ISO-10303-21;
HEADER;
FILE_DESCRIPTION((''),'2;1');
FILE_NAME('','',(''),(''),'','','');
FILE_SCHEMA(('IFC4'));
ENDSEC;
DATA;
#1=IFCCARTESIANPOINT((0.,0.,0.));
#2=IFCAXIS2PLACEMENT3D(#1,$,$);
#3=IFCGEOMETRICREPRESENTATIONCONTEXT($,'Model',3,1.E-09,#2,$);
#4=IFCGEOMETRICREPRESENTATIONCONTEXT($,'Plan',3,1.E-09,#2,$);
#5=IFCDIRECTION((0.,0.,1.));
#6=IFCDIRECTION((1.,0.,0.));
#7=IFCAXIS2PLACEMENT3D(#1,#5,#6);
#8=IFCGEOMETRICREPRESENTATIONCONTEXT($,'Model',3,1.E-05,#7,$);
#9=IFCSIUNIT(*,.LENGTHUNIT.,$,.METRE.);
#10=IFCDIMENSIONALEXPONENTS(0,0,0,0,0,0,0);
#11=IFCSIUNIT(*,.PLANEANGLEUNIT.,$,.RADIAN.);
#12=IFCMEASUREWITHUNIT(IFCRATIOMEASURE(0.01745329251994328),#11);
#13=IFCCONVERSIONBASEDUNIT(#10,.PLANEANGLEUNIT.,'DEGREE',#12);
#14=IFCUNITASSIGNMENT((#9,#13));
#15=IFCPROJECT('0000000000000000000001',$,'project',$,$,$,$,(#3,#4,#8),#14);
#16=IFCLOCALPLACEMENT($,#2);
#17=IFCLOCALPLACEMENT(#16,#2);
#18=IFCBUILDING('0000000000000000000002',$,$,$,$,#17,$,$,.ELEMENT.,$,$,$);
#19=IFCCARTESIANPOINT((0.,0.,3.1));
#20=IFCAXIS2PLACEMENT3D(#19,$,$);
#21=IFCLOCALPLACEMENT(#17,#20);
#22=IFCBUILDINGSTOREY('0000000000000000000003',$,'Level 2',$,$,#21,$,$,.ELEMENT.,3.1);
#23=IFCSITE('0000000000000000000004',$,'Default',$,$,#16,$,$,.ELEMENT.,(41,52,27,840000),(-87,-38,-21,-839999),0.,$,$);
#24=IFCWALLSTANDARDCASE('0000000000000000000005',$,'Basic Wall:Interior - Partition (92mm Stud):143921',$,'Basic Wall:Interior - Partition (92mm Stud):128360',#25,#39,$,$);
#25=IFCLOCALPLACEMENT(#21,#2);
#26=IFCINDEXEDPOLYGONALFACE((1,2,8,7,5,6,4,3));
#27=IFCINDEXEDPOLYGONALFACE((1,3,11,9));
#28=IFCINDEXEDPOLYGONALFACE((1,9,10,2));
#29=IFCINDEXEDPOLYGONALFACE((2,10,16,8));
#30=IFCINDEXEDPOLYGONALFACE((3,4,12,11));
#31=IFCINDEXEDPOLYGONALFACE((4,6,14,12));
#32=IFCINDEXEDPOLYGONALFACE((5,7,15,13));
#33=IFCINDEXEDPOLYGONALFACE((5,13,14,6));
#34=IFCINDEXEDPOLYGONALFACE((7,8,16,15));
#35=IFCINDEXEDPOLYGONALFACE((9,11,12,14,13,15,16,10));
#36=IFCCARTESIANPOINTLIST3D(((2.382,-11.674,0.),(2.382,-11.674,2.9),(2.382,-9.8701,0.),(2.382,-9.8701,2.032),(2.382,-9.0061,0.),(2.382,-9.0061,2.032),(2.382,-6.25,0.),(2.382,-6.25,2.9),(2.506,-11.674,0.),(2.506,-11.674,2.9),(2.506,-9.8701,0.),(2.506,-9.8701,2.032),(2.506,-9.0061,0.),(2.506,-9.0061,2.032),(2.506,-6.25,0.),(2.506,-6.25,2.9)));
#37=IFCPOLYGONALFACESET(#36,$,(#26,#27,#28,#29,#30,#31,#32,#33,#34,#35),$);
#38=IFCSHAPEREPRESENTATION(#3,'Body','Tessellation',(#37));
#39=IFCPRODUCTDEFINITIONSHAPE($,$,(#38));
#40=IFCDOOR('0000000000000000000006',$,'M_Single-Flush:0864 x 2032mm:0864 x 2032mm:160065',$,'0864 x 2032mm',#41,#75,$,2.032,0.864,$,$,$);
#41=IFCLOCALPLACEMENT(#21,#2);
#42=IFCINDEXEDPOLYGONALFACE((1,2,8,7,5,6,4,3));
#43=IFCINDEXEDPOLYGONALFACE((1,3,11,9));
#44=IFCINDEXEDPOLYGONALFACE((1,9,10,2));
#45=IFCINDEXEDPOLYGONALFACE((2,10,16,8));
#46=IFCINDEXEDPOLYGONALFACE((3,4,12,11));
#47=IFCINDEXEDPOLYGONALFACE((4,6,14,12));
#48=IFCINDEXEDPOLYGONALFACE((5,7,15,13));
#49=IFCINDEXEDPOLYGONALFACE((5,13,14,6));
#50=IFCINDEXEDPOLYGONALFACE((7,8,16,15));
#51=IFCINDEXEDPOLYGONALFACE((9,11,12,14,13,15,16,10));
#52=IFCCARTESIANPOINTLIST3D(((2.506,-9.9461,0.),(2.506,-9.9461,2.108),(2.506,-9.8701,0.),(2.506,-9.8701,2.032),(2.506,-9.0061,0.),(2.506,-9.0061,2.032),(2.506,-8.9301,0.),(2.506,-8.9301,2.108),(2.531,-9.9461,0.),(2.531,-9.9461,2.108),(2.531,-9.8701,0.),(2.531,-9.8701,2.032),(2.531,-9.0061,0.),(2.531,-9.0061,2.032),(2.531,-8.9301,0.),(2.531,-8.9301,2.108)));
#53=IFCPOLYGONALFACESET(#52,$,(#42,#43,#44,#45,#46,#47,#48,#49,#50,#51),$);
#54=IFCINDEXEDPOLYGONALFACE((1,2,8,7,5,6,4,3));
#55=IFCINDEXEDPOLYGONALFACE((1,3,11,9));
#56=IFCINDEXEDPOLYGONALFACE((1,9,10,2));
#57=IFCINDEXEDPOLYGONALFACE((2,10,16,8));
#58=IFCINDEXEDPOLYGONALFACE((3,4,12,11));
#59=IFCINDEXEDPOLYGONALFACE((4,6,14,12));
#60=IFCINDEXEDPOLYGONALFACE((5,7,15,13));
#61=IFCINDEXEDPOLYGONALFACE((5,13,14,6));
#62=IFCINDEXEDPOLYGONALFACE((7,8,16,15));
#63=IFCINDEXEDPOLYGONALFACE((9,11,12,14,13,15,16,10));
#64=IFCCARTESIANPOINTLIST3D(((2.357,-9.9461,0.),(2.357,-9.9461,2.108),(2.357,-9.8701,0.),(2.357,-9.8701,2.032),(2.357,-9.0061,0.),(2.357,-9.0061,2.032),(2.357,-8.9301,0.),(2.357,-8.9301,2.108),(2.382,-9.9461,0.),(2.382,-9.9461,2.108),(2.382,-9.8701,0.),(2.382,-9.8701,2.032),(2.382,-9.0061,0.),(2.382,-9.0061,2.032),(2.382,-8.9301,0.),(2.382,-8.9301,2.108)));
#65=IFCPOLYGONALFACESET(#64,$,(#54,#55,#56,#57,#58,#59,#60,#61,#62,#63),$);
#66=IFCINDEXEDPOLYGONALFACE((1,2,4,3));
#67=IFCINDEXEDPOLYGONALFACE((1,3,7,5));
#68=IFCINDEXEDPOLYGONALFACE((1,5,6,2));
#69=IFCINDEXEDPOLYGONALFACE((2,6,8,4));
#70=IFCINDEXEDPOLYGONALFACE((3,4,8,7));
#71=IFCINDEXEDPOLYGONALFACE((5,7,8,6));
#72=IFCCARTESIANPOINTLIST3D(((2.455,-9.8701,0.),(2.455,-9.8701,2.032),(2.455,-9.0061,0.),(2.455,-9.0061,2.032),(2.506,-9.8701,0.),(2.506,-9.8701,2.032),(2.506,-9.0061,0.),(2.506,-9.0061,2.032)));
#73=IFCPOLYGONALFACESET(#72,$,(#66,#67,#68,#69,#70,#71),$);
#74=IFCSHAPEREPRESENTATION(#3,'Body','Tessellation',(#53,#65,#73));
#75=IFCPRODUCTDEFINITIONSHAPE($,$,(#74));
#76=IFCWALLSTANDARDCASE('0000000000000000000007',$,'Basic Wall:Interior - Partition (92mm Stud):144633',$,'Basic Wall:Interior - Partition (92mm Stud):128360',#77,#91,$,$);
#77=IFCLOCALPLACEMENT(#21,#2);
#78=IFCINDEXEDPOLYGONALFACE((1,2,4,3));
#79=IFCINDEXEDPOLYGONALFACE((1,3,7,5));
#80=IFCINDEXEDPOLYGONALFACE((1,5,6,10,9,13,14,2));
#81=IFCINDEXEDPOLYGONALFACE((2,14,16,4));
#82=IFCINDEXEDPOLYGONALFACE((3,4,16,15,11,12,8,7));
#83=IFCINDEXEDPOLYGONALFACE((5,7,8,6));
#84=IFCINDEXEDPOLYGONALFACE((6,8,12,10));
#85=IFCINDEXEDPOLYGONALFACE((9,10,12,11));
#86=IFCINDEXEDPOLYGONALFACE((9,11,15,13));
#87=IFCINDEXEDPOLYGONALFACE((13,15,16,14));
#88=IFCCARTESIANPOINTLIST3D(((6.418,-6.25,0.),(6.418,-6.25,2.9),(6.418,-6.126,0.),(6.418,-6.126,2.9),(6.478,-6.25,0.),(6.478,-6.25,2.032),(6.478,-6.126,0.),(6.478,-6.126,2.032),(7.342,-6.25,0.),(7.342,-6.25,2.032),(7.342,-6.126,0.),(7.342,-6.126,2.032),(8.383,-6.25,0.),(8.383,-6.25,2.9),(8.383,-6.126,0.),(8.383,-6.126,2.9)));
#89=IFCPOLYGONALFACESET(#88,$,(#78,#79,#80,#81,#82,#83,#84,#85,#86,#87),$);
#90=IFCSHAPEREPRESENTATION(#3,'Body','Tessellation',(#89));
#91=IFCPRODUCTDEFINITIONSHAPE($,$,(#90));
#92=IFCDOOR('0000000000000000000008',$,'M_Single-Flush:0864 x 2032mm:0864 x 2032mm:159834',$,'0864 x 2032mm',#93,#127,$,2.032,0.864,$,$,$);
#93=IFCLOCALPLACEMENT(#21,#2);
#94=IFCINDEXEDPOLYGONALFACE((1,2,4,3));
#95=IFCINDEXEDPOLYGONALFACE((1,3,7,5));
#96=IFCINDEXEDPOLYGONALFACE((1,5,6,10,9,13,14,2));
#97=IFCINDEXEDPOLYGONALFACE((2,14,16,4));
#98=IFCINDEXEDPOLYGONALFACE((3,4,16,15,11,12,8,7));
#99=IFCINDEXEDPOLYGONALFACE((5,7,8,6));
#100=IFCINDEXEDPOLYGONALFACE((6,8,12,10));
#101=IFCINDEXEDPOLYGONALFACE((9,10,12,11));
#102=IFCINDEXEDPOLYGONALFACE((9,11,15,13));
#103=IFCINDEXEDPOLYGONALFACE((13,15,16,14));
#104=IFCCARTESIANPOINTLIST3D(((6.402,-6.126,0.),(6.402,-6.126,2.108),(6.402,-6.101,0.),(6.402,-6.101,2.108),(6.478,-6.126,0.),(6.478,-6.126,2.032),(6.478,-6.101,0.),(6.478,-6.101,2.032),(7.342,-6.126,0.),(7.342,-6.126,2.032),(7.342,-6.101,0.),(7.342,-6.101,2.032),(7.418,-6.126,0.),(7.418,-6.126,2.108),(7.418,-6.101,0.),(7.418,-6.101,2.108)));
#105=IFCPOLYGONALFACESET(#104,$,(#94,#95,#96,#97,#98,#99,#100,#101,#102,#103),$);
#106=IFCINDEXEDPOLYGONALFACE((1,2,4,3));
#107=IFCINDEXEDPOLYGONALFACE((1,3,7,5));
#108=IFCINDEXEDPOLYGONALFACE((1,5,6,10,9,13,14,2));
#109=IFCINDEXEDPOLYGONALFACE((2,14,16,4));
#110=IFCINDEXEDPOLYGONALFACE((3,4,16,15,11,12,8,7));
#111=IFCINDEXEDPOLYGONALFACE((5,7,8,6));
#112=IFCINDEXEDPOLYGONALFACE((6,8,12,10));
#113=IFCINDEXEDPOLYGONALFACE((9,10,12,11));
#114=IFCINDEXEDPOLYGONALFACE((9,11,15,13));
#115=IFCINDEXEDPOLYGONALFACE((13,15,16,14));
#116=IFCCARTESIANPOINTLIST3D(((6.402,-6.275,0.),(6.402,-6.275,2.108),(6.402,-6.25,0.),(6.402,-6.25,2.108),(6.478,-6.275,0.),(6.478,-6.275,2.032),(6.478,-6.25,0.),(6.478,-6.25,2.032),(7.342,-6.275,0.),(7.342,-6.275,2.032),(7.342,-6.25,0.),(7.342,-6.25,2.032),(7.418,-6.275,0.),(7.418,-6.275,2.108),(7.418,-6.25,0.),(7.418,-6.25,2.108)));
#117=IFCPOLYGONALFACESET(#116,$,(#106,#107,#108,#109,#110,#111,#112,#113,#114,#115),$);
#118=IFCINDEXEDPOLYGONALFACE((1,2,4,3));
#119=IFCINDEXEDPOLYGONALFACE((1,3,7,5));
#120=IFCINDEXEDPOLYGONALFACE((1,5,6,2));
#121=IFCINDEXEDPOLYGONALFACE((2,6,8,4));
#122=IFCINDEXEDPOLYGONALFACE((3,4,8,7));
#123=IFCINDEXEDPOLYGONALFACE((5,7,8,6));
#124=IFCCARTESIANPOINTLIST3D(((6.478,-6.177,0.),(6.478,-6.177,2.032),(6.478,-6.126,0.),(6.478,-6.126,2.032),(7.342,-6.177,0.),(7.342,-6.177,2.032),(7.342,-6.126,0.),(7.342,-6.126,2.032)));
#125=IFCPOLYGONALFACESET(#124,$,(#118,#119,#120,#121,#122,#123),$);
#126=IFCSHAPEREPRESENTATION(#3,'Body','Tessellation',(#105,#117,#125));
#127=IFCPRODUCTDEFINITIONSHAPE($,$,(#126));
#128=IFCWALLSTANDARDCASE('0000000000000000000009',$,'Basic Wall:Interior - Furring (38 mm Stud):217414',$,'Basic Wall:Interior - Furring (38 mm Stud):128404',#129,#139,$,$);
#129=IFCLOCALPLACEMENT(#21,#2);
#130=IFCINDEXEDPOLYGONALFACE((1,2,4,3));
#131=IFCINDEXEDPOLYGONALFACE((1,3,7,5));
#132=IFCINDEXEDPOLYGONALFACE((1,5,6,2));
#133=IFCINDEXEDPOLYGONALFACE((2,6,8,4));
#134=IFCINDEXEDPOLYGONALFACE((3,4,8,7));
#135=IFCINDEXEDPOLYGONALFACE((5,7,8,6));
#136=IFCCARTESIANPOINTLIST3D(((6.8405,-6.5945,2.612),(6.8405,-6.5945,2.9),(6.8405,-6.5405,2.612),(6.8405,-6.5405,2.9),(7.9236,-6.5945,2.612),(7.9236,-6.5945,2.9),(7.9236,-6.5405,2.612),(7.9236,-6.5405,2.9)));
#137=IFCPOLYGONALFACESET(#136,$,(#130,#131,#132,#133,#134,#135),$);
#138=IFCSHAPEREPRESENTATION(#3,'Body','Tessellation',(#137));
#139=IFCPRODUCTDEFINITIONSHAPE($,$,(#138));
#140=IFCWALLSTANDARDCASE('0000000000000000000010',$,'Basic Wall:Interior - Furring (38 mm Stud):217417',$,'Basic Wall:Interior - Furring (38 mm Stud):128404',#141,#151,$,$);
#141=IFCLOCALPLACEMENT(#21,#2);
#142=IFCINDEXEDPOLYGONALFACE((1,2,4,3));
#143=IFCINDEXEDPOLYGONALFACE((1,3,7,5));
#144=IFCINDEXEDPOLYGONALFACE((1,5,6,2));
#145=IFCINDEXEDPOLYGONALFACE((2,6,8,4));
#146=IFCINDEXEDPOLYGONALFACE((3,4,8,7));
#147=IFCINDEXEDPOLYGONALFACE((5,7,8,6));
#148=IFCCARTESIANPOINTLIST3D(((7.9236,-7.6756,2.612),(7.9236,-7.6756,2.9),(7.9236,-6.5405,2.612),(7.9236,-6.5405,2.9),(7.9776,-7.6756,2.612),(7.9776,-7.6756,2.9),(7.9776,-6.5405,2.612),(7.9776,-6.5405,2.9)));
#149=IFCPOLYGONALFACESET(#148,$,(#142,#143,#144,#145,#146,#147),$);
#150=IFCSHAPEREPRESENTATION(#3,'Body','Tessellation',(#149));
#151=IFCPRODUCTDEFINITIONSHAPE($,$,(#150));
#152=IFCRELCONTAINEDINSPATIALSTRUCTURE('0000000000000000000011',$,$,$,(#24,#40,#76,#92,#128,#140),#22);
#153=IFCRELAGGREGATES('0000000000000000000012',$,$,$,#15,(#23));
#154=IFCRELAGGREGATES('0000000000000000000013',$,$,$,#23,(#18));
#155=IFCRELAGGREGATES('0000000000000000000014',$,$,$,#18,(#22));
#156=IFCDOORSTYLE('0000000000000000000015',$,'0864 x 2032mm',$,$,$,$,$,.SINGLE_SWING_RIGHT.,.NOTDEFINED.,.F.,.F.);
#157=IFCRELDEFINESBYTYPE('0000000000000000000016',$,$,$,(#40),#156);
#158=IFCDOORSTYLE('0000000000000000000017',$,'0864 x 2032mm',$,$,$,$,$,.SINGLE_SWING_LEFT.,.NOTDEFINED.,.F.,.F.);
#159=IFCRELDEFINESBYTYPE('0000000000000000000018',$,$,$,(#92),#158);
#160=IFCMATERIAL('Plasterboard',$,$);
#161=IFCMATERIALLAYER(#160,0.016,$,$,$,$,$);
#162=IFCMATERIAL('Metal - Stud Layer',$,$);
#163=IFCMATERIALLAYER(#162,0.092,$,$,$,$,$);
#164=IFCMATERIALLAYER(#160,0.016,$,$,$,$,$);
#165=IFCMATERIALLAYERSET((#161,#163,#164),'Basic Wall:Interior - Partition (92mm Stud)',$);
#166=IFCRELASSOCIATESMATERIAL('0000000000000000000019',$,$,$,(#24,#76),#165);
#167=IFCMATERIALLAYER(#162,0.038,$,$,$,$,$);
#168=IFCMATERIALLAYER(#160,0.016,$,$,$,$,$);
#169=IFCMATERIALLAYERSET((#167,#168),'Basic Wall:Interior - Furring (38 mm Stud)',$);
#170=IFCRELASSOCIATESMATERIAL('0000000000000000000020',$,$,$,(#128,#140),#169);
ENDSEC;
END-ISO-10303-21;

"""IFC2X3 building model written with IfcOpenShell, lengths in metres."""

from ifc_helpers import new_model, entity, si_unit, converted_unit, frame, frame_2d, origin, origin_with_axes, origin_2d_with_axis, place, context, project, spatial, polyline, rectangle, outline, extrude, source, transform, mapped, material, layer, layer_set, layer_usage, type_object, type_shapes, element, fill, save


model = new_model("IFC2X3")

# Units and contexts
model_context_1 = context("Model", 3, precision=1e-09, world=origin())
plan_context = context("Plan", 3, precision=1e-09, world=origin())
model_context_2 = context("Model", 3, precision=1e-05, world=origin_with_axes())
ifc_project = project(units=[si_unit("LENGTHUNIT", "METRE"), converted_unit("PLANEANGLEUNIT", "DEGREE", entity("IfcRatioMeasure", 0.01745329251994328), si_unit("PLANEANGLEUNIT", "RADIAN"), dimensions=[0, 0, 0, 0, 0, 0, 0])], contexts=[model_context_1, plan_context, model_context_2])

# Site, building, storey
site_placement = place(None, origin())
site = spatial("IfcSite", under=ifc_project, at=site_placement, Name="Default", CompositionType="ELEMENT", RefLatitude=(41, 52, 27, 840000), RefLongitude=(-87, -38, -21, -839999), RefElevation=0.0)
building_placement = place(site_placement, origin())
building = spatial("IfcBuilding", under=site, at=building_placement, CompositionType="ELEMENT")
storey_placement = place(building_placement, frame((0.0, 0.0, 3.1)))
storey = spatial("IfcBuildingStorey", under=building, at=storey_placement, Name="Level 2", CompositionType="ELEMENT", Elevation=3.1)

# Shared definitions
ifc_material_1 = material(Name="Metal - Stud Layer")
ifc_material_2 = material(Name="Plasterboard")

# Walls, openings, doors
ifc_layer_1 = layer(ifc_material_2, 0.016)
ifc_layer_2 = layer(ifc_material_1, 0.092)
ifc_layer_3 = layer(ifc_material_2, 0.016)
ifc_layer_set_1 = layer_set([ifc_layer_1, ifc_layer_2, ifc_layer_3], Name="Basic Wall:Interior - Partition (92mm Stud)")
ifc_layer_usage_1 = layer_usage(ifc_layer_set_1, "AXIS2", "NEGATIVE", 0.062)
wall_1_placement = place(storey_placement, frame((2.444, -6.25, 0.0), z_axis=(0.0, 0.0, 1.0), x_axis=(0.0, -1.0, 0.0)))
wall_1 = element("IfcWallStandardCase", 1, at=wall_1_placement, inside=storey, material=ifc_layer_usage_1, Name="Basic Wall:Interior - Partition (92mm Stud):143921", ObjectType="Basic Wall:Interior - Partition (92mm Stud):128360", context=model_context_1, shape_type="SweptSolid", body=[
    extrude(rectangle(XDim=5.424, YDim=0.124, at=frame_2d((2.712, 0.0), x_axis=(-1.0, 0.0))), origin(), (0.0, 0.0, 1.0), 2.9),
])
opening_1_placement = place(wall_1_placement, frame((2.7561, -0.062, 0.0)))
opening_1 = element("IfcOpeningElement", 2, at=opening_1_placement, cuts=wall_1, ObjectType="Opening", context=model_context_1, shape_type="SweptSolid", body=[
    extrude(rectangle(XDim=0.864, YDim=2.032, at=frame_2d((1.016, 0.432), x_axis=(0.0, 1.0))), frame((0.0, 0.0, 0.0), z_axis=(0.0, 1.0, 0.0), x_axis=(0.0, 0.0, 1.0)), (0.0, 0.0, 1.0), 0.124),
])
door_style_1 = type_object("IfcDoorStyle", Name="0864 x 2032mm", ConstructionType="NOTDEFINED", OperationType="SINGLE_SWING_RIGHT", ParameterTakesPrecedence=False, Sizeable=False)
shared_shape_1 = source(origin(), model_context_1, "Body", "SweptSolid", [
    extrude(outline(polyline([(-0.508, -1.073), (0.508, -1.073), (0.508, 1.035), (0.432, 1.035), (0.432, -0.997), (-0.432, -0.997), (-0.432, 1.035), (-0.508, 1.035), (-0.508, -1.073)])), frame((0.432, 0.124, 1.035), z_axis=(0.0, 1.0, 0.0), x_axis=(1.0, 0.0, 0.0)), (0.0, 0.0, 1.0), 0.025),
    extrude(outline(polyline([(-1.073, -0.508), (1.035, -0.508), (1.035, -0.432), (-0.997, -0.432), (-0.997, 0.432), (1.035, 0.432), (1.035, 0.508), (-1.073, 0.508), (-1.073, -0.508)])), frame((0.432, -0.025, 1.035), z_axis=(0.0, 1.0, 0.0), x_axis=(0.0, 0.0, -1.0)), (0.0, 0.0, 1.0), 0.025),
    extrude(rectangle(XDim=0.051, YDim=0.864, at=origin_2d_with_axis()), frame((0.432, 0.0985, 0.0), z_axis=(0.0, 0.0, 1.0), x_axis=(0.0, 1.0, 0.0)), (0.0, 0.0, 1.0), 2.032),
])
type_shapes(door_style_1, [shared_shape_1])
door_1_placement = place(opening_1_placement, origin())
door_1 = element("IfcDoor", 3, at=door_1_placement, inside=storey, type_object=door_style_1, Name="M_Single-Flush:0864 x 2032mm:0864 x 2032mm:160065", ObjectType="0864 x 2032mm", OverallHeight=2.032, OverallWidth=0.864, context=model_context_1, shape_type="MappedRepresentation", body=[
    mapped(shared_shape_1, transform((0.0, 0.0, 0.0), scale=1.0)),
])
fill(opening_1, door_1)
ifc_layer_usage_2 = layer_usage(ifc_layer_set_1, "AXIS2", "NEGATIVE", 0.062)
wall_2_placement = place(storey_placement, frame((6.418, -6.188, 0.0)))
wall_2 = element("IfcWallStandardCase", 4, at=wall_2_placement, inside=storey, material=ifc_layer_usage_2, Name="Basic Wall:Interior - Partition (92mm Stud):144633", ObjectType="Basic Wall:Interior - Partition (92mm Stud):128360", context=model_context_1, shape_type="SweptSolid", body=[
    extrude(rectangle(XDim=1.965, YDim=0.124, at=frame_2d((0.9825, 0.0), x_axis=(-1.0, 0.0))), origin(), (0.0, 0.0, 1.0), 2.9),
])
opening_2_placement = place(wall_2_placement, frame((0.06, -0.062, 0.0)))
opening_2 = element("IfcOpeningElement", 5, at=opening_2_placement, cuts=wall_2, ObjectType="Opening", context=model_context_1, shape_type="SweptSolid", body=[
    extrude(rectangle(XDim=0.864, YDim=2.032, at=frame_2d((1.016, 0.432), x_axis=(0.0, -1.0))), frame((0.0, 0.0, 0.0), z_axis=(0.0, 1.0, 0.0), x_axis=(0.0, 0.0, 1.0)), (0.0, 0.0, 1.0), 0.124),
])
door_style_2 = type_object("IfcDoorStyle", Name="0864 x 2032mm", ConstructionType="NOTDEFINED", OperationType="SINGLE_SWING_LEFT", ParameterTakesPrecedence=False, Sizeable=False)
shared_shape_2 = source(origin(), model_context_1, "Body", "SweptSolid", [
    extrude(outline(polyline([(-0.508, -1.073), (0.508, -1.073), (0.508, 1.035), (0.432, 1.035), (0.432, -0.997), (-0.432, -0.997), (-0.432, 1.035), (-0.508, 1.035), (-0.508, -1.073)])), frame((0.432, 0.149, 1.035), z_axis=(0.0, -1.0, 0.0), x_axis=(-1.0, 0.0, 0.0)), (0.0, 0.0, 1.0), 0.025),
    extrude(outline(polyline([(-1.073, -0.508), (1.035, -0.508), (1.035, -0.432), (-0.997, -0.432), (-0.997, 0.432), (1.035, 0.432), (1.035, 0.508), (-1.073, 0.508), (-1.073, -0.508)])), frame((0.432, 0.0, 1.035), z_axis=(0.0, -1.0, 0.0), x_axis=(0.0, 0.0, -1.0)), (0.0, 0.0, 1.0), 0.025),
    extrude(rectangle(XDim=0.864, YDim=0.051, at=origin_2d_with_axis()), frame((0.432, 0.0985, 0.0)), (0.0, 0.0, 1.0), 2.032),
])
type_shapes(door_style_2, [shared_shape_2])
door_2_placement = place(opening_2_placement, origin())
door_2 = element("IfcDoor", 6, at=door_2_placement, inside=storey, type_object=door_style_2, Name="M_Single-Flush:0864 x 2032mm:0864 x 2032mm:159834", ObjectType="0864 x 2032mm", OverallHeight=2.032, OverallWidth=0.864, context=model_context_1, shape_type="MappedRepresentation", body=[
    mapped(shared_shape_2, transform((0.0, 0.0, 0.0), scale=1.0)),
])
fill(opening_2, door_2)

# Walls
ifc_layer_4 = layer(ifc_material_1, 0.038)
ifc_layer_5 = layer(ifc_material_2, 0.016)
ifc_layer_set_2 = layer_set([ifc_layer_4, ifc_layer_5], Name="Basic Wall:Interior - Furring (38 mm Stud)")
ifc_layer_usage_3 = layer_usage(ifc_layer_set_2, "AXIS2", "NEGATIVE", 0.027)
wall_3_placement = place(storey_placement, frame((6.8405, -6.5675, 2.612)))
element("IfcWallStandardCase", 7, at=wall_3_placement, inside=storey, material=ifc_layer_usage_3, Name="Basic Wall:Interior - Furring (38 mm Stud):217414", ObjectType="Basic Wall:Interior - Furring (38 mm Stud):128404", context=model_context_1, shape_type="SweptSolid", body=[
    extrude(rectangle(XDim=1.0831, YDim=0.054, at=frame_2d((0.5416, 0.0), x_axis=(-1.0, 0.0))), origin(), (0.0, 0.0, 1.0), 0.288),
])
ifc_layer_usage_4 = layer_usage(ifc_layer_set_2, "AXIS2", "NEGATIVE", 0.027)
wall_4_placement = place(storey_placement, frame((7.9506, -6.5405, 2.612), z_axis=(0.0, 0.0, 1.0), x_axis=(0.0, -1.0, 0.0)))
element("IfcWallStandardCase", 8, at=wall_4_placement, inside=storey, material=ifc_layer_usage_4, Name="Basic Wall:Interior - Furring (38 mm Stud):217417", ObjectType="Basic Wall:Interior - Furring (38 mm Stud):128404", context=model_context_1, shape_type="SweptSolid", body=[
    extrude(rectangle(XDim=1.1351, YDim=0.054, at=frame_2d((0.5675, 0.0), x_axis=(-1.0, 0.0))), origin(), (0.0, 0.0, 1.0), 0.288),
])

save(model, "model.ifc")
